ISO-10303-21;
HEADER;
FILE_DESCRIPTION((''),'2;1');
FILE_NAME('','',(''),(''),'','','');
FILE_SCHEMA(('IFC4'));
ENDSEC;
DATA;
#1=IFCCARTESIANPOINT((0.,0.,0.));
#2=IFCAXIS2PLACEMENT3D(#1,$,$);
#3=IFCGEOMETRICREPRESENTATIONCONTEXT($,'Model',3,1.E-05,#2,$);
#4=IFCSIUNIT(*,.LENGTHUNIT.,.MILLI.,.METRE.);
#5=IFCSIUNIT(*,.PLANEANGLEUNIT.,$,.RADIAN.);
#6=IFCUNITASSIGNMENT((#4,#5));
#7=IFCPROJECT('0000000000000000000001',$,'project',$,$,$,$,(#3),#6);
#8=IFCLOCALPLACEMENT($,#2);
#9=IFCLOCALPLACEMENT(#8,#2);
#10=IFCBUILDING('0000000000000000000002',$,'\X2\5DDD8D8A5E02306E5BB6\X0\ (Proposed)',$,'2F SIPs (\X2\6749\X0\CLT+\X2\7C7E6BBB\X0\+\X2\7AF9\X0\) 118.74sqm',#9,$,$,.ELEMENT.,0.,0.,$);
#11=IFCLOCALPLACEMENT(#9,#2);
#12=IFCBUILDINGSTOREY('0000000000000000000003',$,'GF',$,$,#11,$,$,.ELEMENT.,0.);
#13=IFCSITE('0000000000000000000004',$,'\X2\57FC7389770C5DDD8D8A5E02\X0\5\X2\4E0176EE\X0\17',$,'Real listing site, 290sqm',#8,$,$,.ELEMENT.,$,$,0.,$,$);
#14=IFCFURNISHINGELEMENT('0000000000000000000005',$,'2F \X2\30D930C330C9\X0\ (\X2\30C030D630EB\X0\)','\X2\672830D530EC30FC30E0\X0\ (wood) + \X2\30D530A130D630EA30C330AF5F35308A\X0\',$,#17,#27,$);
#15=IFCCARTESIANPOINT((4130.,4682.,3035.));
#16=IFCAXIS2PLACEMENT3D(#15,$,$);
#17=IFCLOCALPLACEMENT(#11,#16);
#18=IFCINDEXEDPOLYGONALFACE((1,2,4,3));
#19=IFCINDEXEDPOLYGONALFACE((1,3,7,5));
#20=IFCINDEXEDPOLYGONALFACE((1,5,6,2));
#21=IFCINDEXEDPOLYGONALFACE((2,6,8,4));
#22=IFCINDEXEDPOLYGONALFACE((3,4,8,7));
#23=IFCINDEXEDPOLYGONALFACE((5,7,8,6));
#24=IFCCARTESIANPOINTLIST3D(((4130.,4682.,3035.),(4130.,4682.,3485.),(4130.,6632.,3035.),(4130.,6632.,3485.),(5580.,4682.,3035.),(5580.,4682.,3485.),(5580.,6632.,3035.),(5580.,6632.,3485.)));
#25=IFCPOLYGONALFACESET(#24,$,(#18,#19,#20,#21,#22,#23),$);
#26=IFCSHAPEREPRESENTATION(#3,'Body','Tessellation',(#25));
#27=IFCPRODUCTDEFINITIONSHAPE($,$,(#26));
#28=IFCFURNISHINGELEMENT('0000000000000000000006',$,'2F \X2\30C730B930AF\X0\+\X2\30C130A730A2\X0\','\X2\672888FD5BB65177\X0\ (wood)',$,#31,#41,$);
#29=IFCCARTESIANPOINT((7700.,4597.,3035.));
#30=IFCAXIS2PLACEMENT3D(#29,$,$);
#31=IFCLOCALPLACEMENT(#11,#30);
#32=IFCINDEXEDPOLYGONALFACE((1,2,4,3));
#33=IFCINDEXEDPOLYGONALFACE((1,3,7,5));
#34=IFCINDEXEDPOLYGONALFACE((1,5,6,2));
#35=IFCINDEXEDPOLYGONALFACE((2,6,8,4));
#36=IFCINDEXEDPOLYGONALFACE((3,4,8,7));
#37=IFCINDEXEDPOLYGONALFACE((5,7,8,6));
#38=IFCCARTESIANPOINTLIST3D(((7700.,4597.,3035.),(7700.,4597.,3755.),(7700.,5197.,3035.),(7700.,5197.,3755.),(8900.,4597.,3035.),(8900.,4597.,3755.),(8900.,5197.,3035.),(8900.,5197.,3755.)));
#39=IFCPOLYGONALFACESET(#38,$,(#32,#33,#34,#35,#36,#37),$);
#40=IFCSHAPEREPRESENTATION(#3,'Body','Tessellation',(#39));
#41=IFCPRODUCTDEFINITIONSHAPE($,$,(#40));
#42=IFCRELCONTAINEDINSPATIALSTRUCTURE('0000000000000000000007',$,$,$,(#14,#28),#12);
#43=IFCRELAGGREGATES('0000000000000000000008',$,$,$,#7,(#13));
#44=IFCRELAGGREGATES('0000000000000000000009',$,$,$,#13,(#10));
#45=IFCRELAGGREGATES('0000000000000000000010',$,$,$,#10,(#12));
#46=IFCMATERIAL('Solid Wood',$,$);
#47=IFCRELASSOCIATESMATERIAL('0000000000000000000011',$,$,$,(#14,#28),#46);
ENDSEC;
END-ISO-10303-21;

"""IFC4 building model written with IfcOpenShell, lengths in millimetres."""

from ifc_helpers import new_model, si_unit, frame, frame_2d, origin, place, context, project, spatial, rectangle, extrude, material, element, save


model = new_model("IFC4")

# Units and contexts
model_context = context("Model", 3, precision=1e-05, world=origin())
ifc_project = project(units=[si_unit("LENGTHUNIT", "METRE", prefix="MILLI"), si_unit("PLANEANGLEUNIT", "RADIAN")], contexts=[model_context])

# Site, building, storey
site_placement = place(None, origin())
site = spatial("IfcSite", under=ifc_project, at=site_placement, Name="埼玉県川越市5丁目17", ObjectType="Real listing site, 290sqm", CompositionType="ELEMENT", RefElevation=0.0)
building_placement = place(site_placement, origin())
building = spatial("IfcBuilding", under=site, at=building_placement, Name="川越市の家 (Proposed)", ObjectType="2F SIPs (杉CLT+籾殻+竹) 118.74sqm", CompositionType="ELEMENT", ElevationOfRefHeight=0.0, ElevationOfTerrain=0.0)
storey_placement = place(building_placement, origin())
storey = spatial("IfcBuildingStorey", under=building, at=storey_placement, Name="GF", CompositionType="ELEMENT", Elevation=0.0)

# Shared definitions
ifc_material_1 = material(Name="Solid Wood")

# Furnishing elements
furnishing_1_placement = place(storey_placement, frame((4130.0, 4682.0, 3035.0)))
element("IfcFurnishingElement", 1, at=furnishing_1_placement, inside=storey, material=ifc_material_1, Name="2F ベッド (ダブル)", Description="木フレーム (wood) + ファブリック張り", context=model_context, shape_type="SweptSolid", body=[
    extrude(rectangle(XDim=1450.0, YDim=1950.0, at=frame_2d((725.0, 975.0))), frame((4130.0, 4682.0, 3035.0)), (0.0, 0.0, 1.0), 450.0),
])
furnishing_2_placement = place(storey_placement, frame((7700.0, 4597.0, 3035.0)))
element("IfcFurnishingElement", 2, at=furnishing_2_placement, inside=storey, material=ifc_material_1, Name="2F デスク+チェア", Description="木製家具 (wood)", context=model_context, shape_type="SweptSolid", body=[
    extrude(rectangle(XDim=1200.0, YDim=600.0, at=frame_2d((600.0, 300.0))), frame((7700.0, 4597.0, 3035.0)), (0.0, 0.0, 1.0), 720.0),
])

save(model, "model.ifc")
